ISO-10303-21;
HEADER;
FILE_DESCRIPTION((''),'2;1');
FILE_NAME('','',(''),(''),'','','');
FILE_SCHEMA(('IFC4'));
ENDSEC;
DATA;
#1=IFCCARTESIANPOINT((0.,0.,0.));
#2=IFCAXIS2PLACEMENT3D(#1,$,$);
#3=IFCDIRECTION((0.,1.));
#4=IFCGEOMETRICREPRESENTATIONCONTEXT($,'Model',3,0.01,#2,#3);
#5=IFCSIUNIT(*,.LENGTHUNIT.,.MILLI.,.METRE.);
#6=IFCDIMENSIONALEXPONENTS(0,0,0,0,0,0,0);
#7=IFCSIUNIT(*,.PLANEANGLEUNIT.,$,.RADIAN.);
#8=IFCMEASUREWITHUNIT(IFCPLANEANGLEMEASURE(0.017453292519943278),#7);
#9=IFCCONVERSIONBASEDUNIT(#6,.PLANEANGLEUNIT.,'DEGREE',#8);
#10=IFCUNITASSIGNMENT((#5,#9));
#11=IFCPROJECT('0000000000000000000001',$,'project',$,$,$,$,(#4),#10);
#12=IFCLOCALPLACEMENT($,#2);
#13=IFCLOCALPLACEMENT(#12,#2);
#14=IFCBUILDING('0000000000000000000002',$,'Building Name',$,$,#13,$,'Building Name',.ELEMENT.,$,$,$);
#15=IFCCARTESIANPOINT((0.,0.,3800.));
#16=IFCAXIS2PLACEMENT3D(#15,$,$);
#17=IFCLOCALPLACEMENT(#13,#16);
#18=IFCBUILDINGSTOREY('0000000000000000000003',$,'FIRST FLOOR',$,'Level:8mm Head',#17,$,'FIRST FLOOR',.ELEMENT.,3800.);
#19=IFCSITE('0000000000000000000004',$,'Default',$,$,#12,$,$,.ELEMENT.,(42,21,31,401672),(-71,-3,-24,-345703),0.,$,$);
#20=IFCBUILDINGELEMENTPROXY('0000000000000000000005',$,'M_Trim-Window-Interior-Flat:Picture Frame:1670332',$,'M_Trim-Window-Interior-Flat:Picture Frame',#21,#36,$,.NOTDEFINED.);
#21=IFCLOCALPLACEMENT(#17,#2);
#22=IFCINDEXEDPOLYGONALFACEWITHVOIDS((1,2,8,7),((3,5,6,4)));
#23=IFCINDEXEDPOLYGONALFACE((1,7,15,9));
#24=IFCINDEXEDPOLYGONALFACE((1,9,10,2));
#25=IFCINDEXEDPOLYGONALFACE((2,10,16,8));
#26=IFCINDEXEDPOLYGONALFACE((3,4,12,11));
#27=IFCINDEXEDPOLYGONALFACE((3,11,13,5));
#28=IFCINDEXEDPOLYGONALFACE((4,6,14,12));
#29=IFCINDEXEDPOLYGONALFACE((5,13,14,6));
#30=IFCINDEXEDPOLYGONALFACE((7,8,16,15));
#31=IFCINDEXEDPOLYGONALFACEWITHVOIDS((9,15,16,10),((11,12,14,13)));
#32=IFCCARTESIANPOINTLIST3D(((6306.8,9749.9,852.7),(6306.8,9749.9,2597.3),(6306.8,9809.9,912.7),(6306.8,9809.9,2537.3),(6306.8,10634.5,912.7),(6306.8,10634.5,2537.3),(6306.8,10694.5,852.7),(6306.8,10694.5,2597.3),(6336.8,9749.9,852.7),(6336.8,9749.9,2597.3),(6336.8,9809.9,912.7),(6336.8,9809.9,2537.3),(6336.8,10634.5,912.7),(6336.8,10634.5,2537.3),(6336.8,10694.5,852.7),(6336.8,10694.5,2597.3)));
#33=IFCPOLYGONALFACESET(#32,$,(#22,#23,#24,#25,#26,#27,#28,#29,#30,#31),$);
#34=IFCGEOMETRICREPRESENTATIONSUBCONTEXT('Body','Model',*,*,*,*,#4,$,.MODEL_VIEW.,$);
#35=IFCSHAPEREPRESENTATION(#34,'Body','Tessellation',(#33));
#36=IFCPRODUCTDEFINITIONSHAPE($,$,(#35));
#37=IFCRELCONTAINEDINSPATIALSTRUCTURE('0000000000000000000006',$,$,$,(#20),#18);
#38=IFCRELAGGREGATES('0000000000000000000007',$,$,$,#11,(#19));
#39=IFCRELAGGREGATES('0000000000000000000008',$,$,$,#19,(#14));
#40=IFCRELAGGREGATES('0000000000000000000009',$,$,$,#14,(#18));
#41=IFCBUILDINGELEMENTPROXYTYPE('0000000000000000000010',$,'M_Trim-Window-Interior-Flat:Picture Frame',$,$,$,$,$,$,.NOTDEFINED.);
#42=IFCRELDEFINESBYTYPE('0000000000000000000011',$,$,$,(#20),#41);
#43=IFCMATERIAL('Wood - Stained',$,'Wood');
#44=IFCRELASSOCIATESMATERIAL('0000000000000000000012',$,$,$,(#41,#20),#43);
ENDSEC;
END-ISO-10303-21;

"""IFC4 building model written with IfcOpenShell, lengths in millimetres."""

from ifc_helpers import new_model, entity, si_unit, converted_unit, direction, frame, origin, place, context, subcontext, project, spatial, indexed_curve, outline, extrude, source, transform, mapped, material, type_object, type_shapes, element, save


model = new_model("IFC4")

# Units and contexts
model_context = context("Model", 3, precision=0.01, world=origin(), true_north=direction((0.0, 1.0)))
body_context = subcontext(model_context, "Body", "Model", "MODEL_VIEW")
ifc_project = project(units=[si_unit("LENGTHUNIT", "METRE", prefix="MILLI"), converted_unit("PLANEANGLEUNIT", "DEGREE", entity("IfcPlaneAngleMeasure", 0.017453292519943278), si_unit("PLANEANGLEUNIT", "RADIAN"), dimensions=[0, 0, 0, 0, 0, 0, 0])], contexts=[model_context])

# Site, building, storey
site_placement = place(None, origin())
site = spatial("IfcSite", under=ifc_project, at=site_placement, Name="Default", CompositionType="ELEMENT", RefLatitude=(42, 21, 31, 401672), RefLongitude=(-71, -3, -24, -345703), RefElevation=0.0)
building_placement = place(site_placement, origin())
building = spatial("IfcBuilding", under=site, at=building_placement, Name="Building Name", LongName="Building Name", CompositionType="ELEMENT")
storey_placement = place(building_placement, frame((0.0, 0.0, 3800.0)))
storey = spatial("IfcBuildingStorey", under=building, at=storey_placement, Name="FIRST FLOOR", ObjectType="Level:8mm Head", LongName="FIRST FLOOR", CompositionType="ELEMENT", Elevation=3800.0)

# Building element proxy
ifc_material_1 = material(Name="Wood - Stained", Category="Wood")
building_element_proxy_type_1 = type_object("IfcBuildingElementProxyType", Name="M_Trim-Window-Interior-Flat:Picture Frame", PredefinedType="NOTDEFINED", material=ifc_material_1)
shared_shape_1 = source(origin(), body_context, "Body", "SweptSolid", [
    extrude(outline(indexed_curve([(-872.3, -472.3), (872.3, -472.3), (872.3, 472.3), (-872.3, 472.3), (-872.3, -472.3)], self_intersect=False), holes=[indexed_curve([(-812.3, -412.3), (-812.3, 412.3), (812.3, 412.3), (812.3, -412.3), (-812.3, -412.3)], self_intersect=False)]), frame((0.0, 825.0, 0.0), z_axis=(0.0, 0.0, 1.0), x_axis=(0.0, 1.0, 0.0)), (0.0, 0.0, 1.0), 30.0),
])
type_shapes(building_element_proxy_type_1, [shared_shape_1])
for number, where, z_axis, x_axis, name in (
    (1, (6336.8, 10222.2, 2550.0), (-1.0, 0.0, 0.0), (0.0, 1.0, 0.0), "M_Trim-Window-Interior-Flat:Picture Frame:1670332"),
):
    element("IfcBuildingElementProxy", number, at=place(storey_placement, frame(where, z_axis=z_axis, x_axis=x_axis)), inside=storey, type_object=building_element_proxy_type_1, material=ifc_material_1, Name=name, ObjectType="M_Trim-Window-Interior-Flat:Picture Frame", PredefinedType="NOTDEFINED", context=body_context, shape_type="MappedRepresentation", body=[
        mapped(shared_shape_1, transform((0.0, 0.0, 0.0), scale=1.0)),
    ])

save(model, "model.ifc")
